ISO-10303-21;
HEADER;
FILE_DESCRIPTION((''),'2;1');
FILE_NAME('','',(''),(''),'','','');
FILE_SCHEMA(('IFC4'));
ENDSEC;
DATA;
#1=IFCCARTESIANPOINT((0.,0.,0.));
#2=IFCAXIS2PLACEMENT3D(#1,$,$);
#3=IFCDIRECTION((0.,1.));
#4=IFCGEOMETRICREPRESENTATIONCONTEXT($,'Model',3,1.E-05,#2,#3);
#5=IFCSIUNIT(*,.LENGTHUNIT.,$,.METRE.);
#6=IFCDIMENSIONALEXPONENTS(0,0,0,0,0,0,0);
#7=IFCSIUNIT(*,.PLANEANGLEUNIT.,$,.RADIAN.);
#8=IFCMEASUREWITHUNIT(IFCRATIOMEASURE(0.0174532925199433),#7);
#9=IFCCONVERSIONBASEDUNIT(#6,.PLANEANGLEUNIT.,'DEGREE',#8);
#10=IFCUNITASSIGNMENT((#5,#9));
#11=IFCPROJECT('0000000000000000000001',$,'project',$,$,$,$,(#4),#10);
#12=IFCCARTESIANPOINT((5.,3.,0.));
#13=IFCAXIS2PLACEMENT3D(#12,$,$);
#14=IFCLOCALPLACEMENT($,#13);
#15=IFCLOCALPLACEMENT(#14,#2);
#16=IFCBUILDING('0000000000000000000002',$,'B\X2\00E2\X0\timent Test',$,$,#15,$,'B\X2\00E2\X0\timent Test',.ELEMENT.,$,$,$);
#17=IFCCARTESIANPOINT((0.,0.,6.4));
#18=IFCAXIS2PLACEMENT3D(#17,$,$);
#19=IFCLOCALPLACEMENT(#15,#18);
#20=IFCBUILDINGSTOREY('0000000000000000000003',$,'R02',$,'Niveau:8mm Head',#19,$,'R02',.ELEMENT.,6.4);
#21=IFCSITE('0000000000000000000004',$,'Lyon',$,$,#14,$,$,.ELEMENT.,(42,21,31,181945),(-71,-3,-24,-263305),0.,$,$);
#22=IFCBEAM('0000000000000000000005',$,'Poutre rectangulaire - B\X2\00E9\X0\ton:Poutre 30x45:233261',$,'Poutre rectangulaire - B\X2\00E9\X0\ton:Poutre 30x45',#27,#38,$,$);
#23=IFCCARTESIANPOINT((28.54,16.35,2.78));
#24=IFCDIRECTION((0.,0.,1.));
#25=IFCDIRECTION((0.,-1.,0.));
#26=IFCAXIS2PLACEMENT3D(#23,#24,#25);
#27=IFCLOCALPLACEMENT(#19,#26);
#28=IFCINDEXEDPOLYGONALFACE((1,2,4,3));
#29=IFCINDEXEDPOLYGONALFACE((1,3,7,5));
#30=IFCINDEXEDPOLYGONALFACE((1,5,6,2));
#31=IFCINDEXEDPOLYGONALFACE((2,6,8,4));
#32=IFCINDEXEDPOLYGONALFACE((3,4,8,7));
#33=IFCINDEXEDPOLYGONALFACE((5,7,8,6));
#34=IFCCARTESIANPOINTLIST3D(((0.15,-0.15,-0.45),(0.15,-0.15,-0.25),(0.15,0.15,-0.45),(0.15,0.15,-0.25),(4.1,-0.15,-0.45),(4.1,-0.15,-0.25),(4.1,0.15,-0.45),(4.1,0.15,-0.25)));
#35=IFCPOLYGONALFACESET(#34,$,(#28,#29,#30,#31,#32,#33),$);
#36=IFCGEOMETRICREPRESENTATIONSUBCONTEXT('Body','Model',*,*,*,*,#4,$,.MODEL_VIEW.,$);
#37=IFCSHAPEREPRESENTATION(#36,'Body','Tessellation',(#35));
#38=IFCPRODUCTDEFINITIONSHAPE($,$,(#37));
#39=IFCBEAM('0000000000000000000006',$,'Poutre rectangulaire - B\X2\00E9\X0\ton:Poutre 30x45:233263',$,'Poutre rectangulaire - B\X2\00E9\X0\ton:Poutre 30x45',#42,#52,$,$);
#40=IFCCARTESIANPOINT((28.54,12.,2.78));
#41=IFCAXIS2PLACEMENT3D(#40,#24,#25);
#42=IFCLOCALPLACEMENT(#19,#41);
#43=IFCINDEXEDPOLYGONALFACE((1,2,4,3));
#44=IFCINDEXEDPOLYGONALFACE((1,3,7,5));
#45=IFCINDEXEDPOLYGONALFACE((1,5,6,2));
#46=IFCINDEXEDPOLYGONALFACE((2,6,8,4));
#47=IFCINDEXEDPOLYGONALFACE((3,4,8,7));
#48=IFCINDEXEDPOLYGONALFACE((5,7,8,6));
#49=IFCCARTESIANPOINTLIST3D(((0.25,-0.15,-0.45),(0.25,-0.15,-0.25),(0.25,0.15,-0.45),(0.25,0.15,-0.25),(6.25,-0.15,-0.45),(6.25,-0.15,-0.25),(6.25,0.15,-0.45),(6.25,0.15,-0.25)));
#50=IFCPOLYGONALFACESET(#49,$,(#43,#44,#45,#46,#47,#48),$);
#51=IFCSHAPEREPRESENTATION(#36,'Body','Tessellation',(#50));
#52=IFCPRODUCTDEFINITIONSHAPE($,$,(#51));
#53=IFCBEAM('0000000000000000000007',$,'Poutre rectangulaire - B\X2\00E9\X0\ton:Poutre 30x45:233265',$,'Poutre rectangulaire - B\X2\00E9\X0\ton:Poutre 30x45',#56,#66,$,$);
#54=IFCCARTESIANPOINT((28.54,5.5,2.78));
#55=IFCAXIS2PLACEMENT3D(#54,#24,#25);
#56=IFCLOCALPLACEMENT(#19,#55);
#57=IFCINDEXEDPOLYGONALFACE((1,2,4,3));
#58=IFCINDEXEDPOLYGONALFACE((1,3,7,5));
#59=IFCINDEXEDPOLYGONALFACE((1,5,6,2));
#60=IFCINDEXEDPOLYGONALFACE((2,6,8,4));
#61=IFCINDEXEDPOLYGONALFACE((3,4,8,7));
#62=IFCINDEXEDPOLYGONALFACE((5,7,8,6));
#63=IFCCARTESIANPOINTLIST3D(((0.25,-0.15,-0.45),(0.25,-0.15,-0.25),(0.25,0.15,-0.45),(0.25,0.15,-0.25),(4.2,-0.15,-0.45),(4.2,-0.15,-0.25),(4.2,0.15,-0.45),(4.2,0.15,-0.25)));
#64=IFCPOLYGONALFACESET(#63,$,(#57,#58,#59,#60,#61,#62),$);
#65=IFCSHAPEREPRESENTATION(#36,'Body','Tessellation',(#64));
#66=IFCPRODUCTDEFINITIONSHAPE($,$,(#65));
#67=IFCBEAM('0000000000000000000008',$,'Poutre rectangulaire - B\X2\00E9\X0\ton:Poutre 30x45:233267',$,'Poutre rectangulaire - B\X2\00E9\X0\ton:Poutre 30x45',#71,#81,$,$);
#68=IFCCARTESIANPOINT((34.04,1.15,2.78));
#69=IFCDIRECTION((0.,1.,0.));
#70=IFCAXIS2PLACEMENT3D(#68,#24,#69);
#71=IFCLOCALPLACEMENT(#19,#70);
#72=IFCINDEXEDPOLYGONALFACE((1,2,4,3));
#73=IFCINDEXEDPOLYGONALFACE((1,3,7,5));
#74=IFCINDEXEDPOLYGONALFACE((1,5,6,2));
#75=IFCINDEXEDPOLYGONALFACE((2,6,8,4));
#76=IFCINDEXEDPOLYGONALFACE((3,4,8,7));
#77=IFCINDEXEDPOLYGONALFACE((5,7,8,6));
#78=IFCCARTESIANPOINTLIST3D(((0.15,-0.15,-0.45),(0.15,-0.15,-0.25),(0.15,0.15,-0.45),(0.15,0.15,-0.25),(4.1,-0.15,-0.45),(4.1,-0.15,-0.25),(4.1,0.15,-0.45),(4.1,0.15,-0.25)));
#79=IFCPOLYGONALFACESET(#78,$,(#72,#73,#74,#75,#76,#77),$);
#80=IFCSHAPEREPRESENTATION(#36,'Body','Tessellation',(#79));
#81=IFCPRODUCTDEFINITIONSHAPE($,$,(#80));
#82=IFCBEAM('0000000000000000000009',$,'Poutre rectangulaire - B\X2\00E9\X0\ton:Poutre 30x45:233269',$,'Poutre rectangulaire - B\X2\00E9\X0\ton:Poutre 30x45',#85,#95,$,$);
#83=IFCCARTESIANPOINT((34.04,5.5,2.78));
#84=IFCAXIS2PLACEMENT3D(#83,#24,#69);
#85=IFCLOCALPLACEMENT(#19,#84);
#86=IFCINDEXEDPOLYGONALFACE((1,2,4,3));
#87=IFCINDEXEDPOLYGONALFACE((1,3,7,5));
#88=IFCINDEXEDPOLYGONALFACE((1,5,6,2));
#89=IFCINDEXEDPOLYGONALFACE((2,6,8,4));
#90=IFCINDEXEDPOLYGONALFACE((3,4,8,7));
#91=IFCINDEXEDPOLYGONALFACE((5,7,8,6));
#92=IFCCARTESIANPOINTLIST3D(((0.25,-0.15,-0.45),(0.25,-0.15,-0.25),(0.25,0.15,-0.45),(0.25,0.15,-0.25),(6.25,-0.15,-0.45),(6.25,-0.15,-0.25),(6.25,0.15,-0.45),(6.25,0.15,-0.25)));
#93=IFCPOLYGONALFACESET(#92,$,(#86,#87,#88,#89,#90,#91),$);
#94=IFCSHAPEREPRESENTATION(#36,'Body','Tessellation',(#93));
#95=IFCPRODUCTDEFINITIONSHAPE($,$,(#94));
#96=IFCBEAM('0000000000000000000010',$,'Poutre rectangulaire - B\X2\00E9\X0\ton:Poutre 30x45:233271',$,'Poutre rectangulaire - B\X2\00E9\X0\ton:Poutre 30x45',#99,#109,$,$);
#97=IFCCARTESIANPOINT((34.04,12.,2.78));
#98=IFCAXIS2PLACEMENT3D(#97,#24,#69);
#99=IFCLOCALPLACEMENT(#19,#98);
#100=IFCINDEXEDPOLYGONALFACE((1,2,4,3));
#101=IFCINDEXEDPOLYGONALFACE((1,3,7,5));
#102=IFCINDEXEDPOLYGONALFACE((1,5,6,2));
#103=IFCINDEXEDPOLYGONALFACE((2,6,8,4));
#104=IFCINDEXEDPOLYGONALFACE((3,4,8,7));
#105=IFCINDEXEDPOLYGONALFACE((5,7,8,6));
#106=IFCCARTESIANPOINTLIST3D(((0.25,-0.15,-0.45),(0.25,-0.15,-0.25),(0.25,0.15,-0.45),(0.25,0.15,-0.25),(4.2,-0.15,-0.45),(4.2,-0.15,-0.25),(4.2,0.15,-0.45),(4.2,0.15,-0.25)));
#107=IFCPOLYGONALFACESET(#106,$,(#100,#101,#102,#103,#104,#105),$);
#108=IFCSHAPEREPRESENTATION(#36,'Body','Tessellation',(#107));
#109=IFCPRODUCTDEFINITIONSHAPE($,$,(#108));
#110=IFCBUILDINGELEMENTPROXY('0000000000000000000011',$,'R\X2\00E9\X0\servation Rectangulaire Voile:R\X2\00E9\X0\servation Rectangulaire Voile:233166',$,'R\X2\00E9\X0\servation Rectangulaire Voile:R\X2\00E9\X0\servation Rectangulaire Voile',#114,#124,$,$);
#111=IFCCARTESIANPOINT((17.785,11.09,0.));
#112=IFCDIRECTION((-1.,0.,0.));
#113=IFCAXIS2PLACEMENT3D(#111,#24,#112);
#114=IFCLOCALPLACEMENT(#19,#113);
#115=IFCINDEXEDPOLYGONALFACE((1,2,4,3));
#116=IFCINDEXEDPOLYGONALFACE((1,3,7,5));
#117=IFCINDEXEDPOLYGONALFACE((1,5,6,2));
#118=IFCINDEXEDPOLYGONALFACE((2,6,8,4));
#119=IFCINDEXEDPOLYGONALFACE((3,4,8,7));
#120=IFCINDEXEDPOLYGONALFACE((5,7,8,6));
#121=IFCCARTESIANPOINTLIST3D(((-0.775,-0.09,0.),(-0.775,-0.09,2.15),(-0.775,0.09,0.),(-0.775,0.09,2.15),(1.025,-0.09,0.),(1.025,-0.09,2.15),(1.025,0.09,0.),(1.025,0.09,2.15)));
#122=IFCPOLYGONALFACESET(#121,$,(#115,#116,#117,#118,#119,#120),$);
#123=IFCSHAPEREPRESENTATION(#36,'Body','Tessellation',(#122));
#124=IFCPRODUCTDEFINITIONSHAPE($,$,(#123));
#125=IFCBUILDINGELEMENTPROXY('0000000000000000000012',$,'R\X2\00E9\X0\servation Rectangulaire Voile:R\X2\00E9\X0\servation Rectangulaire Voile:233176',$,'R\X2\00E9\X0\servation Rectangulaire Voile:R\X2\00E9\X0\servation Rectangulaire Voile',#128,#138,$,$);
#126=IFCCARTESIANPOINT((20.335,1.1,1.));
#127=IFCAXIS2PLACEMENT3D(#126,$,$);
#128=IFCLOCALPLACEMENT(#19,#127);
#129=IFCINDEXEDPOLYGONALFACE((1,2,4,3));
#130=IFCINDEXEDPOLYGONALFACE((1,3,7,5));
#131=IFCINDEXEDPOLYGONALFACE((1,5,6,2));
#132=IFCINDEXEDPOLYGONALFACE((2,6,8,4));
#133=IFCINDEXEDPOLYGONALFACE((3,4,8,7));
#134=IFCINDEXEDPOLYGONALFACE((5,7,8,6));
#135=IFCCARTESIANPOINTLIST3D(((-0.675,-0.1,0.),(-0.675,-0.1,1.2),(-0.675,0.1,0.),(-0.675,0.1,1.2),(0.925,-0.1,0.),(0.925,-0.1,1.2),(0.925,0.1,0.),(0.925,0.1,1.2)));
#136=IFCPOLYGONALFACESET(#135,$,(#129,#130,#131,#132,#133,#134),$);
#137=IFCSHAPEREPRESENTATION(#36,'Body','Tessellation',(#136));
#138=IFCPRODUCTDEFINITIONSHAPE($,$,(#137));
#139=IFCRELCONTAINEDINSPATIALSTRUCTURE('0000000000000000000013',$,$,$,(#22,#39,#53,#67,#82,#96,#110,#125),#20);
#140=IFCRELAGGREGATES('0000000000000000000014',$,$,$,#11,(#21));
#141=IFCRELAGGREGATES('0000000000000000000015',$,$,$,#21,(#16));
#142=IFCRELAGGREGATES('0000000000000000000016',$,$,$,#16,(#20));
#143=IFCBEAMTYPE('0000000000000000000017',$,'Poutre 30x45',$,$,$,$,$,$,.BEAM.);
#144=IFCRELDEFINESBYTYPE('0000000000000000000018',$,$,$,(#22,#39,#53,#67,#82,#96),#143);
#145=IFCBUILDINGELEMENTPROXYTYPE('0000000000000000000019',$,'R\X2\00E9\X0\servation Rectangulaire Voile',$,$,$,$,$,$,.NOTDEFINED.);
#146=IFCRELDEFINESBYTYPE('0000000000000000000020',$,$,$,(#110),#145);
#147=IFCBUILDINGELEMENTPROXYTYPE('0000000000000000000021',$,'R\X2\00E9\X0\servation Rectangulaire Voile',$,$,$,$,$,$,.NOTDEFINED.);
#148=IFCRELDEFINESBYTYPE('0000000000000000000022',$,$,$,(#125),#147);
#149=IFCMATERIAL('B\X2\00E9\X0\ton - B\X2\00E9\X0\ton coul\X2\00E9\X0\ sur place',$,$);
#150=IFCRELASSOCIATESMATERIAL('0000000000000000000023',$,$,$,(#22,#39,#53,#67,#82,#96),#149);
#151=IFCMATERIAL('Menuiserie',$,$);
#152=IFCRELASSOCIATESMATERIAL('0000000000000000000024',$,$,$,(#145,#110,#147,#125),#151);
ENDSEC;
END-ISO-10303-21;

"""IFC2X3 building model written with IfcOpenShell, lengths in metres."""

from ifc_helpers import new_model, entity, si_unit, converted_unit, direction, frame, frame_2d, origin, origin_2d_with_axis, place, context, subcontext, project, spatial, rectangle, extrude, source, transform, mapped, material, type_object, type_shapes, element, save


model = new_model("IFC2X3")

# Units and contexts
model_context = context("Model", 3, precision=1e-05, world=origin(), true_north=direction((0.0, 1.0)))
body_context = subcontext(model_context, "Body", "Model", "MODEL_VIEW")
ifc_project = project(units=[si_unit("LENGTHUNIT", "METRE"), converted_unit("PLANEANGLEUNIT", "DEGREE", entity("IfcRatioMeasure", 0.0174532925199433), si_unit("PLANEANGLEUNIT", "RADIAN"), dimensions=[0, 0, 0, 0, 0, 0, 0])], contexts=[model_context])

# Site, building, storey
site_placement = place(None, frame((5.0, 3.0, 0.0)))
site = spatial("IfcSite", under=ifc_project, at=site_placement, Name="Lyon", CompositionType="ELEMENT", RefLatitude=(42, 21, 31, 181945), RefLongitude=(-71, -3, -24, -263305), RefElevation=0.0)
building_placement = place(site_placement, origin())
building = spatial("IfcBuilding", under=site, at=building_placement, Name="Bâtiment Test", LongName="Bâtiment Test", CompositionType="ELEMENT")
storey_placement = place(building_placement, frame((0.0, 0.0, 6.4)))
storey = spatial("IfcBuildingStorey", under=building, at=storey_placement, Name="R02", ObjectType="Niveau:8mm Head", LongName="R02", CompositionType="ELEMENT", Elevation=6.4)

# Beams
ifc_material_1 = material(Name="Béton - Béton coulé sur place")
beam_type_1 = type_object("IfcBeamType", Name="Poutre 30x45", PredefinedType="BEAM")
beam_1_placement = place(storey_placement, frame((28.54, 16.35, 2.78), z_axis=(0.0, 0.0, 1.0), x_axis=(0.0, -1.0, 0.0)))
element("IfcBeam", 1, at=beam_1_placement, inside=storey, type_object=beam_type_1, material=ifc_material_1, Name="Poutre rectangulaire - Béton:Poutre 30x45:233261", ObjectType="Poutre rectangulaire - Béton:Poutre 30x45", context=body_context, shape_type="SweptSolid", body=[
    extrude(rectangle(XDim=0.2, YDim=0.3, at=frame_2d((0.0, 0.0), x_axis=(1.0, 0.0))), frame((0.15, 0.0, -0.35), z_axis=(1.0, 0.0, 0.0), x_axis=(0.0, 0.0, -1.0)), (0.0, 0.0, 1.0), 3.95),
])
beam_2_placement = place(storey_placement, frame((28.54, 12.0, 2.78), z_axis=(0.0, 0.0, 1.0), x_axis=(0.0, -1.0, 0.0)))
element("IfcBeam", 2, at=beam_2_placement, inside=storey, type_object=beam_type_1, material=ifc_material_1, Name="Poutre rectangulaire - Béton:Poutre 30x45:233263", ObjectType="Poutre rectangulaire - Béton:Poutre 30x45", context=body_context, shape_type="SweptSolid", body=[
    extrude(rectangle(XDim=0.2, YDim=0.3, at=frame_2d((0.0, 0.0), x_axis=(1.0, 0.0))), frame((0.25, 0.0, -0.35), z_axis=(1.0, 0.0, 0.0), x_axis=(0.0, 0.0, -1.0)), (0.0, 0.0, 1.0), 6.0),
])
beam_3_placement = place(storey_placement, frame((28.54, 5.5, 2.78), z_axis=(0.0, 0.0, 1.0), x_axis=(0.0, -1.0, 0.0)))
element("IfcBeam", 3, at=beam_3_placement, inside=storey, type_object=beam_type_1, material=ifc_material_1, Name="Poutre rectangulaire - Béton:Poutre 30x45:233265", ObjectType="Poutre rectangulaire - Béton:Poutre 30x45", context=body_context, shape_type="SweptSolid", body=[
    extrude(rectangle(XDim=0.2, YDim=0.3, at=frame_2d((0.0, 0.0), x_axis=(1.0, 0.0))), frame((0.25, 0.0, -0.35), z_axis=(1.0, 0.0, 0.0), x_axis=(0.0, 0.0, -1.0)), (0.0, 0.0, 1.0), 3.95),
])
beam_4_placement = place(storey_placement, frame((34.04, 1.15, 2.78), z_axis=(0.0, 0.0, 1.0), x_axis=(0.0, 1.0, 0.0)))
element("IfcBeam", 4, at=beam_4_placement, inside=storey, type_object=beam_type_1, material=ifc_material_1, Name="Poutre rectangulaire - Béton:Poutre 30x45:233267", ObjectType="Poutre rectangulaire - Béton:Poutre 30x45", context=body_context, shape_type="SweptSolid", body=[
    extrude(rectangle(XDim=0.2, YDim=0.3, at=frame_2d((0.0, 0.0), x_axis=(1.0, 0.0))), frame((0.15, 0.0, -0.35), z_axis=(1.0, 0.0, 0.0), x_axis=(0.0, 0.0, -1.0)), (0.0, 0.0, 1.0), 3.95),
])
beam_5_placement = place(storey_placement, frame((34.04, 5.5, 2.78), z_axis=(0.0, 0.0, 1.0), x_axis=(0.0, 1.0, 0.0)))
element("IfcBeam", 5, at=beam_5_placement, inside=storey, type_object=beam_type_1, material=ifc_material_1, Name="Poutre rectangulaire - Béton:Poutre 30x45:233269", ObjectType="Poutre rectangulaire - Béton:Poutre 30x45", context=body_context, shape_type="SweptSolid", body=[
    extrude(rectangle(XDim=0.2, YDim=0.3, at=frame_2d((0.0, 0.0), x_axis=(1.0, 0.0))), frame((0.25, 0.0, -0.35), z_axis=(1.0, 0.0, 0.0), x_axis=(0.0, 0.0, -1.0)), (0.0, 0.0, 1.0), 6.0),
])
beam_6_placement = place(storey_placement, frame((34.04, 12.0, 2.78), z_axis=(0.0, 0.0, 1.0), x_axis=(0.0, 1.0, 0.0)))
element("IfcBeam", 6, at=beam_6_placement, inside=storey, type_object=beam_type_1, material=ifc_material_1, Name="Poutre rectangulaire - Béton:Poutre 30x45:233271", ObjectType="Poutre rectangulaire - Béton:Poutre 30x45", context=body_context, shape_type="SweptSolid", body=[
    extrude(rectangle(XDim=0.2, YDim=0.3, at=frame_2d((0.0, 0.0), x_axis=(1.0, 0.0))), frame((0.25, 0.0, -0.35), z_axis=(1.0, 0.0, 0.0), x_axis=(0.0, 0.0, -1.0)), (0.0, 0.0, 1.0), 3.95),
])

# Building element proxies
ifc_material_2 = material(Name="Menuiserie")
building_element_proxy_type_1 = type_object("IfcBuildingElementProxyType", Name="Réservation Rectangulaire Voile", PredefinedType="NOTDEFINED", material=ifc_material_2)
shared_shape_1 = source(origin(), body_context, "Body", "SweptSolid", [
    extrude(rectangle(XDim=0.18, YDim=1.8, at=origin_2d_with_axis()), frame((0.125, 0.0, 0.0), z_axis=(0.0, 0.0, 1.0), x_axis=(0.0, 1.0, 0.0)), (0.0, 0.0, 1.0), 2.15),
])
type_shapes(building_element_proxy_type_1, [shared_shape_1])
proxy_1_placement = place(storey_placement, frame((17.785, 11.09, 0.0), z_axis=(0.0, 0.0, 1.0), x_axis=(-1.0, 0.0, 0.0)))
element("IfcBuildingElementProxy", 7, at=proxy_1_placement, inside=storey, type_object=building_element_proxy_type_1, material=ifc_material_2, Name="Réservation Rectangulaire Voile:Réservation Rectangulaire Voile:233166", ObjectType="Réservation Rectangulaire Voile:Réservation Rectangulaire Voile", context=body_context, shape_type="MappedRepresentation", body=[
    mapped(shared_shape_1, transform((0.0, 0.0, 0.0), scale=1.0)),
])
building_element_proxy_type_2 = type_object("IfcBuildingElementProxyType", Name="Réservation Rectangulaire Voile", PredefinedType="NOTDEFINED", material=ifc_material_2)
shared_shape_2 = source(origin(), body_context, "Body", "SweptSolid", [
    extrude(rectangle(XDim=0.2, YDim=1.6, at=origin_2d_with_axis()), frame((0.125, 0.0, 0.0), z_axis=(0.0, 0.0, 1.0), x_axis=(0.0, 1.0, 0.0)), (0.0, 0.0, 1.0), 1.2),
])
type_shapes(building_element_proxy_type_2, [shared_shape_2])
proxy_2_placement = place(storey_placement, frame((20.335, 1.1, 1.0)))
element("IfcBuildingElementProxy", 8, at=proxy_2_placement, inside=storey, type_object=building_element_proxy_type_2, material=ifc_material_2, Name="Réservation Rectangulaire Voile:Réservation Rectangulaire Voile:233176", ObjectType="Réservation Rectangulaire Voile:Réservation Rectangulaire Voile", context=body_context, shape_type="MappedRepresentation", body=[
    mapped(shared_shape_2, transform((0.0, 0.0, 0.0), scale=1.0)),
])

save(model, "model.ifc")
